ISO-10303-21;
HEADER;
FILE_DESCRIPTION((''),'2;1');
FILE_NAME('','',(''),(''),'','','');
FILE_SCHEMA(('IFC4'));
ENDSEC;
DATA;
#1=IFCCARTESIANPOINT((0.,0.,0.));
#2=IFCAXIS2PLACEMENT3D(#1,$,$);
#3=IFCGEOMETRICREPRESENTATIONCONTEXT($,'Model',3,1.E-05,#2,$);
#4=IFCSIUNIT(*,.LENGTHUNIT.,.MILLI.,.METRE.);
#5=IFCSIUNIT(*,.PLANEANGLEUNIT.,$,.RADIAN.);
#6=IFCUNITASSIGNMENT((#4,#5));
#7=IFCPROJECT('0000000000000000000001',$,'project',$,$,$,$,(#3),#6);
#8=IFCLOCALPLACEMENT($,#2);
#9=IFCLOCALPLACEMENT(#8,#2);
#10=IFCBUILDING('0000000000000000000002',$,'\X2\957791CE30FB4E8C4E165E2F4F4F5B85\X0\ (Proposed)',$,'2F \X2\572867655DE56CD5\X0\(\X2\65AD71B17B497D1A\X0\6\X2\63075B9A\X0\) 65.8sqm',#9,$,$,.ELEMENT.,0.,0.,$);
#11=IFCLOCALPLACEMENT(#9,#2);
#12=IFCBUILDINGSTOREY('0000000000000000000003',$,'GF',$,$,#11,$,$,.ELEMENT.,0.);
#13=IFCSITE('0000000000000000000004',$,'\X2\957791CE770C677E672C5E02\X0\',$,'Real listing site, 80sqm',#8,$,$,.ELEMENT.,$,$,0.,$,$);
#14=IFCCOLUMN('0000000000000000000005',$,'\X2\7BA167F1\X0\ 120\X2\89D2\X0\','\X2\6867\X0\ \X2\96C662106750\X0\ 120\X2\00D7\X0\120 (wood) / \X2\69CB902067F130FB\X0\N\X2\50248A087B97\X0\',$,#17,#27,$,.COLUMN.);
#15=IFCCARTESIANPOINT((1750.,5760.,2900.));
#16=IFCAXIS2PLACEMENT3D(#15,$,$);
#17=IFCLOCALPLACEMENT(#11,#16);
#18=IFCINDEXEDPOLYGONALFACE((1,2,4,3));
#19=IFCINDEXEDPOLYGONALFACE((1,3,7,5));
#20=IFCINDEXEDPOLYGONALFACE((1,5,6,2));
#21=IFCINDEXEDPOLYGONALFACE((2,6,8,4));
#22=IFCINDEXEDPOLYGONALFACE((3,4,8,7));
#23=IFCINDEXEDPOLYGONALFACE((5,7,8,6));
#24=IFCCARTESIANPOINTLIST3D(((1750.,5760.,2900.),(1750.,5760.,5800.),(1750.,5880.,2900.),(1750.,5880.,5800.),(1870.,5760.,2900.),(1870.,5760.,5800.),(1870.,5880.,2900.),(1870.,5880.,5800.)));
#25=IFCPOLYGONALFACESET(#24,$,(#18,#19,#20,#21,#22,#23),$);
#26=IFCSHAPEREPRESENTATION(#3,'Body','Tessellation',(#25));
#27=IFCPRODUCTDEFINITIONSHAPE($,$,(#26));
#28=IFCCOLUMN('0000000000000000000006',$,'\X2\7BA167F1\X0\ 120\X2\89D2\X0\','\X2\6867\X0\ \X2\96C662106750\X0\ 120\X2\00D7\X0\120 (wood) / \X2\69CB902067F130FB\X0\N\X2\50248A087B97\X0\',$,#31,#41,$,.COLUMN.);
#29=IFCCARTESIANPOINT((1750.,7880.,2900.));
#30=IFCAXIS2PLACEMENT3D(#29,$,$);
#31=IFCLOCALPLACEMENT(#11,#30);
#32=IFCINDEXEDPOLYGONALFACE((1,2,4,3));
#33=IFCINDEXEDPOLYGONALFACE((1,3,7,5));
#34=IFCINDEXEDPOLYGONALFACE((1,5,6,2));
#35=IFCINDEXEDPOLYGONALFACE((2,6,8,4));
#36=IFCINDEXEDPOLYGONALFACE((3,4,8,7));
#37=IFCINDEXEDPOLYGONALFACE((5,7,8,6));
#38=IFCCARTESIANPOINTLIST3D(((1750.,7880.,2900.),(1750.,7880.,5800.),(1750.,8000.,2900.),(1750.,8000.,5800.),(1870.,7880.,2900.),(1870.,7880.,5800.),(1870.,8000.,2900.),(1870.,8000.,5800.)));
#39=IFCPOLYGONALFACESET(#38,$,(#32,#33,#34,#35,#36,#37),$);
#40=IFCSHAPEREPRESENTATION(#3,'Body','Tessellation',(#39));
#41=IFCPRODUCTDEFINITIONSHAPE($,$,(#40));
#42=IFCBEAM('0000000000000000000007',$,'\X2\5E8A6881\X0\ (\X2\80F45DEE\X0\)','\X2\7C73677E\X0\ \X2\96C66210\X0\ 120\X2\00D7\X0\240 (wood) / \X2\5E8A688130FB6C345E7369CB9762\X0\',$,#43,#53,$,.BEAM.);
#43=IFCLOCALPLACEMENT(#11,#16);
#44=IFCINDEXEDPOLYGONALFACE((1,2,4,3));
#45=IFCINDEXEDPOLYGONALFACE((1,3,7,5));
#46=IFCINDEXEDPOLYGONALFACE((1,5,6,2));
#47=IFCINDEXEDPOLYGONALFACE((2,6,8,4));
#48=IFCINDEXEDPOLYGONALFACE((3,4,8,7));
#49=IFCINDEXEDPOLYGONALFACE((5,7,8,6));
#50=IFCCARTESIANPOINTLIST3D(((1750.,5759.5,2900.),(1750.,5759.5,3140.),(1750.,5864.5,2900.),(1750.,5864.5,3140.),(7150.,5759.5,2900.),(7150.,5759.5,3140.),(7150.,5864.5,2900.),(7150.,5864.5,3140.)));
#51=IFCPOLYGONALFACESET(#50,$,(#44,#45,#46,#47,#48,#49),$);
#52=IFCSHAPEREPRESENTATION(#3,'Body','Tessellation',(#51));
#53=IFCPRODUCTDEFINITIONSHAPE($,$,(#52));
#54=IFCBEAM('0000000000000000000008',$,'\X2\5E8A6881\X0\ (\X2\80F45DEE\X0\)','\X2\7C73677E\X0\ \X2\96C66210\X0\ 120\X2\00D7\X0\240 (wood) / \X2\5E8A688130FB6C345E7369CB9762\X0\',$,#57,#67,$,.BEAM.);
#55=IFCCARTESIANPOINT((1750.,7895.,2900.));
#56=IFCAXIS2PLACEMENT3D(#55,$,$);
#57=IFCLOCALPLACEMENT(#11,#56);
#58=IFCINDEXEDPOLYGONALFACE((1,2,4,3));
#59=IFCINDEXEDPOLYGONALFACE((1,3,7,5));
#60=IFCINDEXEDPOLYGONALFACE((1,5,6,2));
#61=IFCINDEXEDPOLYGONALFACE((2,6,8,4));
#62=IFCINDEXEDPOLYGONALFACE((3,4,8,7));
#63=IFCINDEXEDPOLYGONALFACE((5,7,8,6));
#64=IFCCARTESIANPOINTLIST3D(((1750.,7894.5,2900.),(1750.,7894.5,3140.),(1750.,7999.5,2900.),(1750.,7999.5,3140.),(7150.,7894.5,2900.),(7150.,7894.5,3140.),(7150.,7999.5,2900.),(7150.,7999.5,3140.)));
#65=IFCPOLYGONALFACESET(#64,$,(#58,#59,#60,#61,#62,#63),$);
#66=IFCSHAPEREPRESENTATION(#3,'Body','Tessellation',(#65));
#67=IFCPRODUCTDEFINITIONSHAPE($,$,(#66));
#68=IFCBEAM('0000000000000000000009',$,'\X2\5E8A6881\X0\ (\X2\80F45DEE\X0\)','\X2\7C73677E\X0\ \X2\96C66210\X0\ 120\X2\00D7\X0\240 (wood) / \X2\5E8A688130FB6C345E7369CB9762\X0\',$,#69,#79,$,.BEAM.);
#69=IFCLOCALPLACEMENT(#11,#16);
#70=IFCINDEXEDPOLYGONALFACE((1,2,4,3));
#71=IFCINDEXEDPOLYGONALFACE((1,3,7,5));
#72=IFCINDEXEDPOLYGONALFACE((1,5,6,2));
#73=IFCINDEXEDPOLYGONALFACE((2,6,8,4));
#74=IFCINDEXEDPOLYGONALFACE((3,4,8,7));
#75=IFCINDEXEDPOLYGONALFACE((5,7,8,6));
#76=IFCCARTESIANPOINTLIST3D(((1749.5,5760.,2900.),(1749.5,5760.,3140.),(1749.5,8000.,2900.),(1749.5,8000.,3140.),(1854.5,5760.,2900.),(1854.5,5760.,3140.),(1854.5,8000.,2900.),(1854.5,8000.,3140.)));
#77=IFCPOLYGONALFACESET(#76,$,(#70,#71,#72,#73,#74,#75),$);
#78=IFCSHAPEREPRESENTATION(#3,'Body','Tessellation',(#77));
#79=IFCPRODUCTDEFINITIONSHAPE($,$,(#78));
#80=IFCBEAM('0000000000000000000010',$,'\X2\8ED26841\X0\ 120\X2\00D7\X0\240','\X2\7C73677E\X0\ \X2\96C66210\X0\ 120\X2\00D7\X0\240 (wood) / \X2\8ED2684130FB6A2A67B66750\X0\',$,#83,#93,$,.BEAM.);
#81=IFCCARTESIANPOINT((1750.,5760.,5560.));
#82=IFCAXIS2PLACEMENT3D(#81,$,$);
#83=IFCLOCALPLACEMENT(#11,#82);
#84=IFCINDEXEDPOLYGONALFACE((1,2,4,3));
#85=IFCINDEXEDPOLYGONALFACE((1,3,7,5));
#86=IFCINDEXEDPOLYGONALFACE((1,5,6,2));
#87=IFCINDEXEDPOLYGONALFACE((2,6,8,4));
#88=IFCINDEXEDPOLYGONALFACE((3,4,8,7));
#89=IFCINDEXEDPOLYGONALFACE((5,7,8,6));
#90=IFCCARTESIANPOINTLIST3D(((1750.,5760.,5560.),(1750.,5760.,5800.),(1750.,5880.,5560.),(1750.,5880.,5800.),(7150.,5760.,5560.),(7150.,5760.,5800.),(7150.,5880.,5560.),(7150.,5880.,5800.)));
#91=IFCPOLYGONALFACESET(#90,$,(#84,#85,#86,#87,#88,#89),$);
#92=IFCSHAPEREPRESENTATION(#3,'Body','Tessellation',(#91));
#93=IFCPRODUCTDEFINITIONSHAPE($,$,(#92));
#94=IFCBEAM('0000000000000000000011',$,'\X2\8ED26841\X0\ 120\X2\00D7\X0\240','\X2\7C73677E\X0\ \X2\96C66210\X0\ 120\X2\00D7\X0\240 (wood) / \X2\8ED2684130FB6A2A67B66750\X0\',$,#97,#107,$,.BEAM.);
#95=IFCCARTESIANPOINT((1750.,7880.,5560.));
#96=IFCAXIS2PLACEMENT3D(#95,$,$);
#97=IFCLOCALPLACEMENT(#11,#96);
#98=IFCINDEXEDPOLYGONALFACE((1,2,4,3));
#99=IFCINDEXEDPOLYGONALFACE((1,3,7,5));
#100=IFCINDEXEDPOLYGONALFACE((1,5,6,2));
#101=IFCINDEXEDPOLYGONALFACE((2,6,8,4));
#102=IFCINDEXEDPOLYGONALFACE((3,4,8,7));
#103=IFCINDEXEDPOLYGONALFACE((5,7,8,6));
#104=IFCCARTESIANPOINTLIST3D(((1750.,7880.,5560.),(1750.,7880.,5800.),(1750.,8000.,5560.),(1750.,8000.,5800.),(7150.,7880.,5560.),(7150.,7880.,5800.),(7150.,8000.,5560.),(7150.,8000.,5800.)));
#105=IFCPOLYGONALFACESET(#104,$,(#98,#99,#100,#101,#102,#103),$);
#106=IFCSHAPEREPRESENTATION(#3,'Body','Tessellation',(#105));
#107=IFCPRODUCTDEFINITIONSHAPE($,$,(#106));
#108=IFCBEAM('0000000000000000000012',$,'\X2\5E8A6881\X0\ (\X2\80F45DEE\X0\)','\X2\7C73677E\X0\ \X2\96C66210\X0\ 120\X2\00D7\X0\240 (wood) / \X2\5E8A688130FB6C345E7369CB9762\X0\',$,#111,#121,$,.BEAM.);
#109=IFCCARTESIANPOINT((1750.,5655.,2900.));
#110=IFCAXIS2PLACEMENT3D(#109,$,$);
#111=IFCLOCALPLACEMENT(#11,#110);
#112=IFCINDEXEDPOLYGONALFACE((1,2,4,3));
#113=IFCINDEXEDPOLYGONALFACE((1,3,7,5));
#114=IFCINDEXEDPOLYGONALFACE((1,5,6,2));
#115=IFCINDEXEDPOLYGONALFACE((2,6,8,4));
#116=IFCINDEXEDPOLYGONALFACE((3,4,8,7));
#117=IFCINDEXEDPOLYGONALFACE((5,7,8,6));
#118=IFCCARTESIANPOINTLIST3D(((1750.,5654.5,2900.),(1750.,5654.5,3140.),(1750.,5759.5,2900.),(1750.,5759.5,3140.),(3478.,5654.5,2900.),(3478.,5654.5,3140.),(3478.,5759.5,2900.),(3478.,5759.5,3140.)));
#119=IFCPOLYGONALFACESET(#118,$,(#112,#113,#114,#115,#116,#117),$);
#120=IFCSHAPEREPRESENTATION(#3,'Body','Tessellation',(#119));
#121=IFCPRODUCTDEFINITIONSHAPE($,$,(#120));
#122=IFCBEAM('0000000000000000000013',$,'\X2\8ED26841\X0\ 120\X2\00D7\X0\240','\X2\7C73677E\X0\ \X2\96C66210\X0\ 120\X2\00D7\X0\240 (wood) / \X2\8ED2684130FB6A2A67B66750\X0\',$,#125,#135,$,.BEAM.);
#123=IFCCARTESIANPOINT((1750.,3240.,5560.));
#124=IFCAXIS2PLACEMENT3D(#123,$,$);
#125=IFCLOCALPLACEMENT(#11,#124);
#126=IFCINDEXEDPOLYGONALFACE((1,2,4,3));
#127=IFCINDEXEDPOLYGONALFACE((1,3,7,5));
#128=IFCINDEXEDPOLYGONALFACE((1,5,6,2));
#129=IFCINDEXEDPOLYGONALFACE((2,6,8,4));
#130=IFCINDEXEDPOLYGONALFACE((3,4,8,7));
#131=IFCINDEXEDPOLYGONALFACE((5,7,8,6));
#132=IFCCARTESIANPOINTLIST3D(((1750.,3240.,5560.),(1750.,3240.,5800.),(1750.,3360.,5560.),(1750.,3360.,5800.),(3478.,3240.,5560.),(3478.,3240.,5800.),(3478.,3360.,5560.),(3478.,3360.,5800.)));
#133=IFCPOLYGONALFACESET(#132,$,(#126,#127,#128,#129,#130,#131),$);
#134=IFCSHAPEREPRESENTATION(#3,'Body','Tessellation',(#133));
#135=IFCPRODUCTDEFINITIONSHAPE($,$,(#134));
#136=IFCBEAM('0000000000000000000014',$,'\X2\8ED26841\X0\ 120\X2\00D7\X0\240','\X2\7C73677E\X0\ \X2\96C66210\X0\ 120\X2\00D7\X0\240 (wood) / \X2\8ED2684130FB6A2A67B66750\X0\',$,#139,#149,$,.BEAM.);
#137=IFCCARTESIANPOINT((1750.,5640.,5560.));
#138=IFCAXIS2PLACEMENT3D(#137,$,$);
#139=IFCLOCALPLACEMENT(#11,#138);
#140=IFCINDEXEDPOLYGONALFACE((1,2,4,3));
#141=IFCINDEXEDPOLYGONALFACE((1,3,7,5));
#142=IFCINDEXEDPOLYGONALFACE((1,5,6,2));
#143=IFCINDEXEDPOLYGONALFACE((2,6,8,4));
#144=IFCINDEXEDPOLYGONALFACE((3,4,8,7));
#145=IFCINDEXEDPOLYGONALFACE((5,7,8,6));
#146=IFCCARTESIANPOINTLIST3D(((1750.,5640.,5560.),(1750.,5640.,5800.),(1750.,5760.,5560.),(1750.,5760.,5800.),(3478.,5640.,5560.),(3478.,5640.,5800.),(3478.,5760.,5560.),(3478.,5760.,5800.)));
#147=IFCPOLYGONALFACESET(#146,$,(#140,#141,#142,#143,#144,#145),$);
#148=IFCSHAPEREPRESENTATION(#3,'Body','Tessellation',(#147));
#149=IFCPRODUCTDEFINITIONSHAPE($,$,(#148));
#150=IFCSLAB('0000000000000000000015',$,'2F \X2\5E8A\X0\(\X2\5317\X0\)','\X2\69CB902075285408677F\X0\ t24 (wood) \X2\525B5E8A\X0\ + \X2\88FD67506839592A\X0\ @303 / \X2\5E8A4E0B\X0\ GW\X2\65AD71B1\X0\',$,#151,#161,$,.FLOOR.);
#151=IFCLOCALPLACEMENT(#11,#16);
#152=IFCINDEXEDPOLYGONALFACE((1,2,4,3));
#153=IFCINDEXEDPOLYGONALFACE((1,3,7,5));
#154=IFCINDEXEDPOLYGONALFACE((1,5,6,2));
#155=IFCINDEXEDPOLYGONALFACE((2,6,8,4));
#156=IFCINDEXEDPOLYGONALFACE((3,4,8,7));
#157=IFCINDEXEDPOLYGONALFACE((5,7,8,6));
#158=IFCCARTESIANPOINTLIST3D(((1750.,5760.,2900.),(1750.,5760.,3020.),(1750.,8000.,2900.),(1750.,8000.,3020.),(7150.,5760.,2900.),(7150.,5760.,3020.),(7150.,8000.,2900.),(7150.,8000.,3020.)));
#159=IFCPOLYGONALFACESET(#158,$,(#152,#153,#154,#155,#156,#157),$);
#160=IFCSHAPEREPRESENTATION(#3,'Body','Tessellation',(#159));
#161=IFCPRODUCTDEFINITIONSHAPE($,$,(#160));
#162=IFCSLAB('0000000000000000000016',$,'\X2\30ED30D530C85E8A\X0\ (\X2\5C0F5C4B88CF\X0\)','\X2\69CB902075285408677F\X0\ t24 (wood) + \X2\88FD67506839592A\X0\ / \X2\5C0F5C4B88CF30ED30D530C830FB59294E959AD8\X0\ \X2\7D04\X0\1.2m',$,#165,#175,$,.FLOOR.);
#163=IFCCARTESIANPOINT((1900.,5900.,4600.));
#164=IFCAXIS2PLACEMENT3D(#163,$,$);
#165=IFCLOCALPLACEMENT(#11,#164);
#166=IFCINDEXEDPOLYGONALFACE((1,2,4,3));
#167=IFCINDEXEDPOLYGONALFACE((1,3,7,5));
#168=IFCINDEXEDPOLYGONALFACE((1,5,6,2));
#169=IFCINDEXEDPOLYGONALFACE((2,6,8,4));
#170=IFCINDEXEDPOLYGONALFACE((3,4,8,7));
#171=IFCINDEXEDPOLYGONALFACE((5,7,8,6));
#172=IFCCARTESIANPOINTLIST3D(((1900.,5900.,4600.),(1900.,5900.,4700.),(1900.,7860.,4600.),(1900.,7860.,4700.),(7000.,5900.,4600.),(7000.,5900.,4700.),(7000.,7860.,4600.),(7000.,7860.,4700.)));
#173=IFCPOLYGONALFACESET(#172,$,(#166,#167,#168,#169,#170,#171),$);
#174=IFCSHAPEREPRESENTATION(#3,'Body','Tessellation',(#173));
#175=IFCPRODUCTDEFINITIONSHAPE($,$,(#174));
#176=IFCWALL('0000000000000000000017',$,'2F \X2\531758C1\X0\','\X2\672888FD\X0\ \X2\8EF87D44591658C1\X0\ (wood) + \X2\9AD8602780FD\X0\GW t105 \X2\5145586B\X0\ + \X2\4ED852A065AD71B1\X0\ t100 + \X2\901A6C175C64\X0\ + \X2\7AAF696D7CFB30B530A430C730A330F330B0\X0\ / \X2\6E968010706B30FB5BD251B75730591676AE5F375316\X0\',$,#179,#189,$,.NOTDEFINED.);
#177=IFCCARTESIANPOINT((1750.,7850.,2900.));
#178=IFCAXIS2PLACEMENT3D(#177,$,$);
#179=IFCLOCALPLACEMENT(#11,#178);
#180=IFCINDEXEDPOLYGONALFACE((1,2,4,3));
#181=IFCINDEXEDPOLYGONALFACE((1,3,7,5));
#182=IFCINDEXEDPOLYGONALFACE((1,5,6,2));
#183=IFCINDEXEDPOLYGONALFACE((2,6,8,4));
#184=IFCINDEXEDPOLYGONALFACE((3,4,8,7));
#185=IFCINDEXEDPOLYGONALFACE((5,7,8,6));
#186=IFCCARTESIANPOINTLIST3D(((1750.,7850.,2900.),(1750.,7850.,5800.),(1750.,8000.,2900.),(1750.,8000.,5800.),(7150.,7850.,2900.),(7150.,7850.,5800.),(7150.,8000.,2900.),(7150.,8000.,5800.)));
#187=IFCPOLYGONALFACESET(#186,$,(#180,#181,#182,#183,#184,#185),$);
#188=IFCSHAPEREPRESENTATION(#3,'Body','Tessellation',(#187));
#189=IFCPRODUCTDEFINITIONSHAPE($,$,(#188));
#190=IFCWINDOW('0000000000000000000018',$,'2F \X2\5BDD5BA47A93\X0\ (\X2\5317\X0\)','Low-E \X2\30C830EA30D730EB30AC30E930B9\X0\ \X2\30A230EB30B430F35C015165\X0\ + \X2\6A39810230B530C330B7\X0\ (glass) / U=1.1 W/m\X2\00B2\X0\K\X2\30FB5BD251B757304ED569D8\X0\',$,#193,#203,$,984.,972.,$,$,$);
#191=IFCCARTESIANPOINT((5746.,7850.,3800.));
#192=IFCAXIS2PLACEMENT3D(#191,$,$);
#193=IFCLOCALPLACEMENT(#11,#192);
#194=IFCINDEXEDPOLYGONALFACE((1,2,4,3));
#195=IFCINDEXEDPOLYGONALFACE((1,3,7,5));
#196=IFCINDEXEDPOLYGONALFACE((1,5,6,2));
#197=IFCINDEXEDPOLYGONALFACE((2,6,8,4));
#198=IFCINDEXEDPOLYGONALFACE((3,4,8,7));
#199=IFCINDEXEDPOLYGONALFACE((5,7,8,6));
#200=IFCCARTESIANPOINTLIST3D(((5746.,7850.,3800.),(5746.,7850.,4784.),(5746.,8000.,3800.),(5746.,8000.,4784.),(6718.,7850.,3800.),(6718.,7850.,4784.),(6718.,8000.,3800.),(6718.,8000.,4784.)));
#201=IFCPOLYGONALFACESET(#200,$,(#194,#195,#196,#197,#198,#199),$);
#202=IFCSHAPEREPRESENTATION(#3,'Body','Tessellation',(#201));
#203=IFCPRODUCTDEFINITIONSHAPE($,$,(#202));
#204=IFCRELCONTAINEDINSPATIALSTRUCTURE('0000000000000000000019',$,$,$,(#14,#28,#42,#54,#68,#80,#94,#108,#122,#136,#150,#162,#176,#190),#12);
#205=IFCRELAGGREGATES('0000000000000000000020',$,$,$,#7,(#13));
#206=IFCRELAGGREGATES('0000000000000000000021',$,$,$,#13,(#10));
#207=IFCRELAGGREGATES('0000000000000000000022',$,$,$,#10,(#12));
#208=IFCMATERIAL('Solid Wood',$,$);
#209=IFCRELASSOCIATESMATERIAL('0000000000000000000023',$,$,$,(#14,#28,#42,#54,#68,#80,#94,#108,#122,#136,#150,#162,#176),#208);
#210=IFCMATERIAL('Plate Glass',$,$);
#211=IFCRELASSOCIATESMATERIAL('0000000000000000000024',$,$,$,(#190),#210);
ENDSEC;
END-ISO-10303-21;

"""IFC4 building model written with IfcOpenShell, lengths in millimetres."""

from ifc_helpers import new_model, si_unit, frame, frame_2d, origin, place, context, project, spatial, rectangle, extrude, material, element, fill, save


model = new_model("IFC4")

# Units and contexts
model_context = context("Model", 3, precision=1e-05, world=origin())
ifc_project = project(units=[si_unit("LENGTHUNIT", "METRE", prefix="MILLI"), si_unit("PLANEANGLEUNIT", "RADIAN")], contexts=[model_context])

# Site, building, storey
site_placement = place(None, origin())
site = spatial("IfcSite", under=ifc_project, at=site_placement, Name="長野県松本市", ObjectType="Real listing site, 80sqm", CompositionType="ELEMENT", RefElevation=0.0)
building_placement = place(site_placement, origin())
building = spatial("IfcBuilding", under=site, at=building_placement, Name="長野・二世帯住宅 (Proposed)", ObjectType="2F 在来工法(断熱等級6指定) 65.8sqm", CompositionType="ELEMENT", ElevationOfRefHeight=0.0, ElevationOfTerrain=0.0)
storey_placement = place(building_placement, origin())
storey = spatial("IfcBuildingStorey", under=building, at=storey_placement, Name="GF", CompositionType="ELEMENT", Elevation=0.0)

# Columns
ifc_material_1 = material(Name="Solid Wood")
column_1_placement = place(storey_placement, frame((1750.0, 5760.0, 2900.0)))
element("IfcColumn", 1, at=column_1_placement, inside=storey, material=ifc_material_1, Name="管柱 120角", Description="桧 集成材 120×120 (wood) / 構造柱・N値計算", PredefinedType="COLUMN", context=model_context, shape_type="SweptSolid", body=[
    extrude(rectangle(XDim=120.0, YDim=120.0, at=frame_2d((60.0, 60.0))), frame((1750.0, 5760.0, 2900.0)), (0.0, 0.0, 1.0), 2900.0),
])
column_2_placement = place(storey_placement, frame((1750.0, 7880.0, 2900.0)))
element("IfcColumn", 2, at=column_2_placement, inside=storey, material=ifc_material_1, Name="管柱 120角", Description="桧 集成材 120×120 (wood) / 構造柱・N値計算", PredefinedType="COLUMN", context=model_context, shape_type="SweptSolid", body=[
    extrude(rectangle(XDim=120.0, YDim=120.0, at=frame_2d((60.0, 60.0))), frame((1750.0, 7880.0, 2900.0)), (0.0, 0.0, 1.0), 2900.0),
])

# Beams
beam_1_placement = place(storey_placement, frame((1750.0, 5760.0, 2900.0)))
element("IfcBeam", 3, at=beam_1_placement, inside=storey, material=ifc_material_1, Name="床梁 (胴差)", Description="米松 集成 120×240 (wood) / 床梁・水平構面", PredefinedType="BEAM", context=model_context, shape_type="SweptSolid", body=[
    extrude(rectangle(XDim=5400.0, YDim=105.0, at=frame_2d((2700.0, 52.0))), frame((1750.0, 5760.0, 2900.0)), (0.0, 0.0, 1.0), 240.0),
])
beam_2_placement = place(storey_placement, frame((1750.0, 7895.0, 2900.0)))
element("IfcBeam", 4, at=beam_2_placement, inside=storey, material=ifc_material_1, Name="床梁 (胴差)", Description="米松 集成 120×240 (wood) / 床梁・水平構面", PredefinedType="BEAM", context=model_context, shape_type="SweptSolid", body=[
    extrude(rectangle(XDim=5400.0, YDim=105.0, at=frame_2d((2700.0, 52.0))), frame((1750.0, 7895.0, 2900.0)), (0.0, 0.0, 1.0), 240.0),
])
beam_3_placement = place(storey_placement, frame((1750.0, 5760.0, 2900.0)))
element("IfcBeam", 5, at=beam_3_placement, inside=storey, material=ifc_material_1, Name="床梁 (胴差)", Description="米松 集成 120×240 (wood) / 床梁・水平構面", PredefinedType="BEAM", context=model_context, shape_type="SweptSolid", body=[
    extrude(rectangle(XDim=105.0, YDim=2240.0, at=frame_2d((52.0, 1120.0))), frame((1750.0, 5760.0, 2900.0)), (0.0, 0.0, 1.0), 240.0),
])
beam_4_placement = place(storey_placement, frame((1750.0, 5760.0, 5560.0)))
element("IfcBeam", 6, at=beam_4_placement, inside=storey, material=ifc_material_1, Name="軒桁 120×240", Description="米松 集成 120×240 (wood) / 軒桁・横架材", PredefinedType="BEAM", context=model_context, shape_type="SweptSolid", body=[
    extrude(rectangle(XDim=5400.0, YDim=120.0, at=frame_2d((2700.0, 60.0))), frame((1750.0, 5760.0, 5560.0)), (0.0, 0.0, 1.0), 240.0),
])
beam_5_placement = place(storey_placement, frame((1750.0, 7880.0, 5560.0)))
element("IfcBeam", 7, at=beam_5_placement, inside=storey, material=ifc_material_1, Name="軒桁 120×240", Description="米松 集成 120×240 (wood) / 軒桁・横架材", PredefinedType="BEAM", context=model_context, shape_type="SweptSolid", body=[
    extrude(rectangle(XDim=5400.0, YDim=120.0, at=frame_2d((2700.0, 60.0))), frame((1750.0, 7880.0, 5560.0)), (0.0, 0.0, 1.0), 240.0),
])
beam_6_placement = place(storey_placement, frame((1750.0, 5655.0, 2900.0)))
element("IfcBeam", 8, at=beam_6_placement, inside=storey, material=ifc_material_1, Name="床梁 (胴差)", Description="米松 集成 120×240 (wood) / 床梁・水平構面", PredefinedType="BEAM", context=model_context, shape_type="SweptSolid", body=[
    extrude(rectangle(XDim=1728.0, YDim=105.0, at=frame_2d((864.0, 52.0))), frame((1750.0, 5655.0, 2900.0)), (0.0, 0.0, 1.0), 240.0),
])
beam_7_placement = place(storey_placement, frame((1750.0, 3240.0, 5560.0)))
element("IfcBeam", 9, at=beam_7_placement, inside=storey, material=ifc_material_1, Name="軒桁 120×240", Description="米松 集成 120×240 (wood) / 軒桁・横架材", PredefinedType="BEAM", context=model_context, shape_type="SweptSolid", body=[
    extrude(rectangle(XDim=1728.0, YDim=120.0, at=frame_2d((864.0, 60.0))), frame((1750.0, 3240.0, 5560.0)), (0.0, 0.0, 1.0), 240.0),
])
beam_8_placement = place(storey_placement, frame((1750.0, 5640.0, 5560.0)))
element("IfcBeam", 10, at=beam_8_placement, inside=storey, material=ifc_material_1, Name="軒桁 120×240", Description="米松 集成 120×240 (wood) / 軒桁・横架材", PredefinedType="BEAM", context=model_context, shape_type="SweptSolid", body=[
    extrude(rectangle(XDim=1728.0, YDim=120.0, at=frame_2d((864.0, 60.0))), frame((1750.0, 5640.0, 5560.0)), (0.0, 0.0, 1.0), 240.0),
])

# Slabs
slab_1_placement = place(storey_placement, frame((1750.0, 5760.0, 2900.0)))
element("IfcSlab", 11, at=slab_1_placement, inside=storey, material=ifc_material_1, Name="2F 床(北)", Description="構造用合板 t24 (wood) 剛床 + 製材根太 @303 / 床下 GW断熱", PredefinedType="FLOOR", context=model_context, shape_type="SweptSolid", body=[
    extrude(rectangle(XDim=5400.0, YDim=2240.0, at=frame_2d((2700.0, 1120.0))), frame((1750.0, 5760.0, 2900.0)), (0.0, 0.0, 1.0), 120.0),
])
slab_2_placement = place(storey_placement, frame((1900.0, 5900.0, 4600.0)))
element("IfcSlab", 12, at=slab_2_placement, inside=storey, material=ifc_material_1, Name="ロフト床 (小屋裏)", Description="構造用合板 t24 (wood) + 製材根太 / 小屋裏ロフト・天井高 約1.2m", PredefinedType="FLOOR", context=model_context, shape_type="SweptSolid", body=[
    extrude(rectangle(XDim=5100.0, YDim=1960.0, at=frame_2d((2550.0, 980.0))), frame((1900.0, 5900.0, 4600.0)), (0.0, 0.0, 1.0), 100.0),
])

# Wall, opening, window
wall_placement = place(storey_placement, frame((1750.0, 7850.0, 2900.0)))
wall = element("IfcWall", 13, at=wall_placement, inside=storey, material=ifc_material_1, Name="2F 北壁", Description="木製 軸組外壁 (wood) + 高性能GW t105 充填 + 付加断熱 t100 + 通気層 + 窯業系サイディング / 準耐火・寒冷地外皮強化", PredefinedType="NOTDEFINED", context=model_context, shape_type="SweptSolid", body=[
    extrude(rectangle(XDim=5400.0, YDim=150.0, at=frame_2d((2700.0, 75.0))), frame((1750.0, 7850.0, 2900.0)), (0.0, 0.0, 1.0), 2900.0),
])
opening_placement = place(storey_placement, frame((5746.0, 7850.0, 3800.0)))
opening = element("IfcOpeningElement", 14, at=opening_placement, cuts=wall, PredefinedType="NOTDEFINED", context=model_context, shape_type="SweptSolid", body=[
    extrude(rectangle(XDim=972.0, YDim=150.0, at=frame_2d((486.0, 75.0))), frame((5746.0, 7850.0, 3800.0)), (0.0, 0.0, 1.0), 984.0),
])
ifc_material_2 = material(Name="Plate Glass")
window_placement = place(storey_placement, frame((5746.0, 7850.0, 3800.0)))
window = element("IfcWindow", 15, at=window_placement, inside=storey, material=ifc_material_2, Name="2F 寝室窓 (北)", Description="Low-E トリプルガラス アルゴン封入 + 樹脂サッシ (glass) / U=1.1 W/m²K・寒冷地仕様", OverallHeight=984.0, OverallWidth=972.0, context=model_context, shape_type="SweptSolid", body=[
    extrude(rectangle(XDim=972.0, YDim=150.0, at=frame_2d((486.0, 75.0))), frame((5746.0, 7850.0, 3800.0)), (0.0, 0.0, 1.0), 984.0),
])
fill(opening, window)

save(model, "model.ifc")
